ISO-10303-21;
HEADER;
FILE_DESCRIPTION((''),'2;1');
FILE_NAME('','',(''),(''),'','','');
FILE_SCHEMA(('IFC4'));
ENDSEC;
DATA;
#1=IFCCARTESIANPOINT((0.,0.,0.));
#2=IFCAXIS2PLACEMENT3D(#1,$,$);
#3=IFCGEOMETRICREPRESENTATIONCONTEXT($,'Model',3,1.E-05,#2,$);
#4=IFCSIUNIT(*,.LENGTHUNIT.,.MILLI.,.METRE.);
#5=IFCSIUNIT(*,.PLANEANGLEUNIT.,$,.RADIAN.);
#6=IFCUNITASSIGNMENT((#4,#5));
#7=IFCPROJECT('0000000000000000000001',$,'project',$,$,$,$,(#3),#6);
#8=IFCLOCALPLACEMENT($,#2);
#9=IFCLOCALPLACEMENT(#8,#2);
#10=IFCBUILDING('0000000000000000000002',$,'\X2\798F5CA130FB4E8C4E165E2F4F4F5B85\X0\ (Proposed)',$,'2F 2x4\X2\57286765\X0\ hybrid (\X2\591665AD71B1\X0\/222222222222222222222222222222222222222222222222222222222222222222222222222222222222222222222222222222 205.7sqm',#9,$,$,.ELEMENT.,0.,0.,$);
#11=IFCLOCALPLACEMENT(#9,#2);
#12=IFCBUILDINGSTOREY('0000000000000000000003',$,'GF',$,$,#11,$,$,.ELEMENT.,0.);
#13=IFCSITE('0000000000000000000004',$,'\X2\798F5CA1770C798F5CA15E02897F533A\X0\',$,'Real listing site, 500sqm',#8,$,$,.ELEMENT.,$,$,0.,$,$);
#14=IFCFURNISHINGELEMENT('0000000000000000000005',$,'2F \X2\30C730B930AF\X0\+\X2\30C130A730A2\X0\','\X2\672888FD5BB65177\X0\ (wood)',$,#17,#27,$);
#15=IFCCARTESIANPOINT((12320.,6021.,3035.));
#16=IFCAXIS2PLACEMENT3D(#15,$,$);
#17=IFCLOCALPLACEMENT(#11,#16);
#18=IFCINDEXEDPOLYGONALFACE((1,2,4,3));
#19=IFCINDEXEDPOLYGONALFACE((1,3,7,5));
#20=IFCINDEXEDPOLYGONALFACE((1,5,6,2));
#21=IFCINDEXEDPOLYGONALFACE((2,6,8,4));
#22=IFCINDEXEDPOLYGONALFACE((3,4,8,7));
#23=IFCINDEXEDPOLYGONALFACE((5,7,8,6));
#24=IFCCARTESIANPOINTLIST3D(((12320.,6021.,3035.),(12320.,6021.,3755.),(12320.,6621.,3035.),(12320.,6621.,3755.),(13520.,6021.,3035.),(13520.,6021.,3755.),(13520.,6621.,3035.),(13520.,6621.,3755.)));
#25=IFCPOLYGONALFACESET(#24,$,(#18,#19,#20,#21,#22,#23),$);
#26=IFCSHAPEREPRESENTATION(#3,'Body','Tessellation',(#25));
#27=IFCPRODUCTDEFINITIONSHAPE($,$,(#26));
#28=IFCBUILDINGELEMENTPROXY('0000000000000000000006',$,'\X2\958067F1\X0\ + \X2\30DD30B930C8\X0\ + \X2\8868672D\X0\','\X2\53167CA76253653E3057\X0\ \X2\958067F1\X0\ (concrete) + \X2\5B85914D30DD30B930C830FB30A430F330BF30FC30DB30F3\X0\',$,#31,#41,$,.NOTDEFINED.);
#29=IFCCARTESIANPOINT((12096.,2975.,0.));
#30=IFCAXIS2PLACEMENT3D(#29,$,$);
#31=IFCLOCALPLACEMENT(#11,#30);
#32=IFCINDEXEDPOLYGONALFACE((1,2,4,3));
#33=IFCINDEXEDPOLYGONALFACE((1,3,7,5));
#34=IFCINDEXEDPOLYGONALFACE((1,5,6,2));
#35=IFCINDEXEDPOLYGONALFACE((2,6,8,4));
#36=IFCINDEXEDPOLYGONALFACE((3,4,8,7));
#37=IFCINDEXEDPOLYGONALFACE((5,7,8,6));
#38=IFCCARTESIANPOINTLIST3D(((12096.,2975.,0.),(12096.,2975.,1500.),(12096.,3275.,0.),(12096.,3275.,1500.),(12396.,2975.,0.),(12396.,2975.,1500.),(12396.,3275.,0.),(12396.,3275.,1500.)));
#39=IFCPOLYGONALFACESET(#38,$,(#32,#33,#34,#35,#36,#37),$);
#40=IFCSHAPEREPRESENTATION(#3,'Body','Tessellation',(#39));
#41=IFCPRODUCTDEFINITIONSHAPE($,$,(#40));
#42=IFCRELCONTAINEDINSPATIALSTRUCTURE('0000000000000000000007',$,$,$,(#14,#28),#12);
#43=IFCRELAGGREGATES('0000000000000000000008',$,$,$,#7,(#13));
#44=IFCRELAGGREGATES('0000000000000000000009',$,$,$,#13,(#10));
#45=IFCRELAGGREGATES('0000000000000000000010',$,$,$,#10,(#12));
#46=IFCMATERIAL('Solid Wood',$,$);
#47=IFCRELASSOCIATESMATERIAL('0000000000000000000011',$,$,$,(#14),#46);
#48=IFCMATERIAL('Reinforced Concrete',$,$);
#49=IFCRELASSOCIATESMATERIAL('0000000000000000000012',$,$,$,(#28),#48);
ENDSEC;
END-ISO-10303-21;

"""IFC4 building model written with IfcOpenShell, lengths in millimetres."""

from ifc_helpers import new_model, si_unit, frame, frame_2d, origin, place, context, project, spatial, rectangle, extrude, material, element, save


model = new_model("IFC4")

# Units and contexts
model_context = context("Model", 3, precision=1e-05, world=origin())
ifc_project = project(units=[si_unit("LENGTHUNIT", "METRE", prefix="MILLI"), si_unit("PLANEANGLEUNIT", "RADIAN")], contexts=[model_context])

# Site, building, storey
site_placement = place(None, origin())
site = spatial("IfcSite", under=ifc_project, at=site_placement, Name="福岡県福岡市西区", ObjectType="Real listing site, 500sqm", CompositionType="ELEMENT", RefElevation=0.0)
building_placement = place(site_placement, origin())
building = spatial("IfcBuilding", under=site, at=building_placement, Name="福岡・二世帯住宅 (Proposed)", ObjectType="2F 2x4在来 hybrid (外断熱/222222222222222222222222222222222222222222222222222222222222222222222222222222222222222222222222222222 205.7sqm", CompositionType="ELEMENT", ElevationOfRefHeight=0.0, ElevationOfTerrain=0.0)
storey_placement = place(building_placement, origin())
storey = spatial("IfcBuildingStorey", under=building, at=storey_placement, Name="GF", CompositionType="ELEMENT", Elevation=0.0)

# Shared definitions
ifc_material_1 = material(Name="Solid Wood")

# Shared definitions
ifc_material_2 = material(Name="Reinforced Concrete")

# Furnishing element
furnishing_1_placement = place(storey_placement, frame((12320.0, 6021.0, 3035.0)))
element("IfcFurnishingElement", 1, at=furnishing_1_placement, inside=storey, material=ifc_material_1, Name="2F デスク+チェア", Description="木製家具 (wood)", context=model_context, shape_type="SweptSolid", body=[
    extrude(rectangle(XDim=1200.0, YDim=600.0, at=frame_2d((600.0, 300.0))), frame((12320.0, 6021.0, 3035.0)), (0.0, 0.0, 1.0), 720.0),
])

# Building element proxy
proxy_placement = place(storey_placement, frame((12096.0, 2975.0, 0.0)))
element("IfcBuildingElementProxy", 2, at=proxy_placement, inside=storey, material=ifc_material_2, Name="門柱 + ポスト + 表札", Description="化粧打放し 門柱 (concrete) + 宅配ポスト・インターホン", PredefinedType="NOTDEFINED", context=model_context, shape_type="SweptSolid", body=[
    extrude(rectangle(XDim=300.0, YDim=300.0, at=frame_2d((150.0, 150.0))), frame((12096.0, 2975.0, 0.0)), (0.0, 0.0, 1.0), 1500.0),
])

save(model, "model.ifc")
